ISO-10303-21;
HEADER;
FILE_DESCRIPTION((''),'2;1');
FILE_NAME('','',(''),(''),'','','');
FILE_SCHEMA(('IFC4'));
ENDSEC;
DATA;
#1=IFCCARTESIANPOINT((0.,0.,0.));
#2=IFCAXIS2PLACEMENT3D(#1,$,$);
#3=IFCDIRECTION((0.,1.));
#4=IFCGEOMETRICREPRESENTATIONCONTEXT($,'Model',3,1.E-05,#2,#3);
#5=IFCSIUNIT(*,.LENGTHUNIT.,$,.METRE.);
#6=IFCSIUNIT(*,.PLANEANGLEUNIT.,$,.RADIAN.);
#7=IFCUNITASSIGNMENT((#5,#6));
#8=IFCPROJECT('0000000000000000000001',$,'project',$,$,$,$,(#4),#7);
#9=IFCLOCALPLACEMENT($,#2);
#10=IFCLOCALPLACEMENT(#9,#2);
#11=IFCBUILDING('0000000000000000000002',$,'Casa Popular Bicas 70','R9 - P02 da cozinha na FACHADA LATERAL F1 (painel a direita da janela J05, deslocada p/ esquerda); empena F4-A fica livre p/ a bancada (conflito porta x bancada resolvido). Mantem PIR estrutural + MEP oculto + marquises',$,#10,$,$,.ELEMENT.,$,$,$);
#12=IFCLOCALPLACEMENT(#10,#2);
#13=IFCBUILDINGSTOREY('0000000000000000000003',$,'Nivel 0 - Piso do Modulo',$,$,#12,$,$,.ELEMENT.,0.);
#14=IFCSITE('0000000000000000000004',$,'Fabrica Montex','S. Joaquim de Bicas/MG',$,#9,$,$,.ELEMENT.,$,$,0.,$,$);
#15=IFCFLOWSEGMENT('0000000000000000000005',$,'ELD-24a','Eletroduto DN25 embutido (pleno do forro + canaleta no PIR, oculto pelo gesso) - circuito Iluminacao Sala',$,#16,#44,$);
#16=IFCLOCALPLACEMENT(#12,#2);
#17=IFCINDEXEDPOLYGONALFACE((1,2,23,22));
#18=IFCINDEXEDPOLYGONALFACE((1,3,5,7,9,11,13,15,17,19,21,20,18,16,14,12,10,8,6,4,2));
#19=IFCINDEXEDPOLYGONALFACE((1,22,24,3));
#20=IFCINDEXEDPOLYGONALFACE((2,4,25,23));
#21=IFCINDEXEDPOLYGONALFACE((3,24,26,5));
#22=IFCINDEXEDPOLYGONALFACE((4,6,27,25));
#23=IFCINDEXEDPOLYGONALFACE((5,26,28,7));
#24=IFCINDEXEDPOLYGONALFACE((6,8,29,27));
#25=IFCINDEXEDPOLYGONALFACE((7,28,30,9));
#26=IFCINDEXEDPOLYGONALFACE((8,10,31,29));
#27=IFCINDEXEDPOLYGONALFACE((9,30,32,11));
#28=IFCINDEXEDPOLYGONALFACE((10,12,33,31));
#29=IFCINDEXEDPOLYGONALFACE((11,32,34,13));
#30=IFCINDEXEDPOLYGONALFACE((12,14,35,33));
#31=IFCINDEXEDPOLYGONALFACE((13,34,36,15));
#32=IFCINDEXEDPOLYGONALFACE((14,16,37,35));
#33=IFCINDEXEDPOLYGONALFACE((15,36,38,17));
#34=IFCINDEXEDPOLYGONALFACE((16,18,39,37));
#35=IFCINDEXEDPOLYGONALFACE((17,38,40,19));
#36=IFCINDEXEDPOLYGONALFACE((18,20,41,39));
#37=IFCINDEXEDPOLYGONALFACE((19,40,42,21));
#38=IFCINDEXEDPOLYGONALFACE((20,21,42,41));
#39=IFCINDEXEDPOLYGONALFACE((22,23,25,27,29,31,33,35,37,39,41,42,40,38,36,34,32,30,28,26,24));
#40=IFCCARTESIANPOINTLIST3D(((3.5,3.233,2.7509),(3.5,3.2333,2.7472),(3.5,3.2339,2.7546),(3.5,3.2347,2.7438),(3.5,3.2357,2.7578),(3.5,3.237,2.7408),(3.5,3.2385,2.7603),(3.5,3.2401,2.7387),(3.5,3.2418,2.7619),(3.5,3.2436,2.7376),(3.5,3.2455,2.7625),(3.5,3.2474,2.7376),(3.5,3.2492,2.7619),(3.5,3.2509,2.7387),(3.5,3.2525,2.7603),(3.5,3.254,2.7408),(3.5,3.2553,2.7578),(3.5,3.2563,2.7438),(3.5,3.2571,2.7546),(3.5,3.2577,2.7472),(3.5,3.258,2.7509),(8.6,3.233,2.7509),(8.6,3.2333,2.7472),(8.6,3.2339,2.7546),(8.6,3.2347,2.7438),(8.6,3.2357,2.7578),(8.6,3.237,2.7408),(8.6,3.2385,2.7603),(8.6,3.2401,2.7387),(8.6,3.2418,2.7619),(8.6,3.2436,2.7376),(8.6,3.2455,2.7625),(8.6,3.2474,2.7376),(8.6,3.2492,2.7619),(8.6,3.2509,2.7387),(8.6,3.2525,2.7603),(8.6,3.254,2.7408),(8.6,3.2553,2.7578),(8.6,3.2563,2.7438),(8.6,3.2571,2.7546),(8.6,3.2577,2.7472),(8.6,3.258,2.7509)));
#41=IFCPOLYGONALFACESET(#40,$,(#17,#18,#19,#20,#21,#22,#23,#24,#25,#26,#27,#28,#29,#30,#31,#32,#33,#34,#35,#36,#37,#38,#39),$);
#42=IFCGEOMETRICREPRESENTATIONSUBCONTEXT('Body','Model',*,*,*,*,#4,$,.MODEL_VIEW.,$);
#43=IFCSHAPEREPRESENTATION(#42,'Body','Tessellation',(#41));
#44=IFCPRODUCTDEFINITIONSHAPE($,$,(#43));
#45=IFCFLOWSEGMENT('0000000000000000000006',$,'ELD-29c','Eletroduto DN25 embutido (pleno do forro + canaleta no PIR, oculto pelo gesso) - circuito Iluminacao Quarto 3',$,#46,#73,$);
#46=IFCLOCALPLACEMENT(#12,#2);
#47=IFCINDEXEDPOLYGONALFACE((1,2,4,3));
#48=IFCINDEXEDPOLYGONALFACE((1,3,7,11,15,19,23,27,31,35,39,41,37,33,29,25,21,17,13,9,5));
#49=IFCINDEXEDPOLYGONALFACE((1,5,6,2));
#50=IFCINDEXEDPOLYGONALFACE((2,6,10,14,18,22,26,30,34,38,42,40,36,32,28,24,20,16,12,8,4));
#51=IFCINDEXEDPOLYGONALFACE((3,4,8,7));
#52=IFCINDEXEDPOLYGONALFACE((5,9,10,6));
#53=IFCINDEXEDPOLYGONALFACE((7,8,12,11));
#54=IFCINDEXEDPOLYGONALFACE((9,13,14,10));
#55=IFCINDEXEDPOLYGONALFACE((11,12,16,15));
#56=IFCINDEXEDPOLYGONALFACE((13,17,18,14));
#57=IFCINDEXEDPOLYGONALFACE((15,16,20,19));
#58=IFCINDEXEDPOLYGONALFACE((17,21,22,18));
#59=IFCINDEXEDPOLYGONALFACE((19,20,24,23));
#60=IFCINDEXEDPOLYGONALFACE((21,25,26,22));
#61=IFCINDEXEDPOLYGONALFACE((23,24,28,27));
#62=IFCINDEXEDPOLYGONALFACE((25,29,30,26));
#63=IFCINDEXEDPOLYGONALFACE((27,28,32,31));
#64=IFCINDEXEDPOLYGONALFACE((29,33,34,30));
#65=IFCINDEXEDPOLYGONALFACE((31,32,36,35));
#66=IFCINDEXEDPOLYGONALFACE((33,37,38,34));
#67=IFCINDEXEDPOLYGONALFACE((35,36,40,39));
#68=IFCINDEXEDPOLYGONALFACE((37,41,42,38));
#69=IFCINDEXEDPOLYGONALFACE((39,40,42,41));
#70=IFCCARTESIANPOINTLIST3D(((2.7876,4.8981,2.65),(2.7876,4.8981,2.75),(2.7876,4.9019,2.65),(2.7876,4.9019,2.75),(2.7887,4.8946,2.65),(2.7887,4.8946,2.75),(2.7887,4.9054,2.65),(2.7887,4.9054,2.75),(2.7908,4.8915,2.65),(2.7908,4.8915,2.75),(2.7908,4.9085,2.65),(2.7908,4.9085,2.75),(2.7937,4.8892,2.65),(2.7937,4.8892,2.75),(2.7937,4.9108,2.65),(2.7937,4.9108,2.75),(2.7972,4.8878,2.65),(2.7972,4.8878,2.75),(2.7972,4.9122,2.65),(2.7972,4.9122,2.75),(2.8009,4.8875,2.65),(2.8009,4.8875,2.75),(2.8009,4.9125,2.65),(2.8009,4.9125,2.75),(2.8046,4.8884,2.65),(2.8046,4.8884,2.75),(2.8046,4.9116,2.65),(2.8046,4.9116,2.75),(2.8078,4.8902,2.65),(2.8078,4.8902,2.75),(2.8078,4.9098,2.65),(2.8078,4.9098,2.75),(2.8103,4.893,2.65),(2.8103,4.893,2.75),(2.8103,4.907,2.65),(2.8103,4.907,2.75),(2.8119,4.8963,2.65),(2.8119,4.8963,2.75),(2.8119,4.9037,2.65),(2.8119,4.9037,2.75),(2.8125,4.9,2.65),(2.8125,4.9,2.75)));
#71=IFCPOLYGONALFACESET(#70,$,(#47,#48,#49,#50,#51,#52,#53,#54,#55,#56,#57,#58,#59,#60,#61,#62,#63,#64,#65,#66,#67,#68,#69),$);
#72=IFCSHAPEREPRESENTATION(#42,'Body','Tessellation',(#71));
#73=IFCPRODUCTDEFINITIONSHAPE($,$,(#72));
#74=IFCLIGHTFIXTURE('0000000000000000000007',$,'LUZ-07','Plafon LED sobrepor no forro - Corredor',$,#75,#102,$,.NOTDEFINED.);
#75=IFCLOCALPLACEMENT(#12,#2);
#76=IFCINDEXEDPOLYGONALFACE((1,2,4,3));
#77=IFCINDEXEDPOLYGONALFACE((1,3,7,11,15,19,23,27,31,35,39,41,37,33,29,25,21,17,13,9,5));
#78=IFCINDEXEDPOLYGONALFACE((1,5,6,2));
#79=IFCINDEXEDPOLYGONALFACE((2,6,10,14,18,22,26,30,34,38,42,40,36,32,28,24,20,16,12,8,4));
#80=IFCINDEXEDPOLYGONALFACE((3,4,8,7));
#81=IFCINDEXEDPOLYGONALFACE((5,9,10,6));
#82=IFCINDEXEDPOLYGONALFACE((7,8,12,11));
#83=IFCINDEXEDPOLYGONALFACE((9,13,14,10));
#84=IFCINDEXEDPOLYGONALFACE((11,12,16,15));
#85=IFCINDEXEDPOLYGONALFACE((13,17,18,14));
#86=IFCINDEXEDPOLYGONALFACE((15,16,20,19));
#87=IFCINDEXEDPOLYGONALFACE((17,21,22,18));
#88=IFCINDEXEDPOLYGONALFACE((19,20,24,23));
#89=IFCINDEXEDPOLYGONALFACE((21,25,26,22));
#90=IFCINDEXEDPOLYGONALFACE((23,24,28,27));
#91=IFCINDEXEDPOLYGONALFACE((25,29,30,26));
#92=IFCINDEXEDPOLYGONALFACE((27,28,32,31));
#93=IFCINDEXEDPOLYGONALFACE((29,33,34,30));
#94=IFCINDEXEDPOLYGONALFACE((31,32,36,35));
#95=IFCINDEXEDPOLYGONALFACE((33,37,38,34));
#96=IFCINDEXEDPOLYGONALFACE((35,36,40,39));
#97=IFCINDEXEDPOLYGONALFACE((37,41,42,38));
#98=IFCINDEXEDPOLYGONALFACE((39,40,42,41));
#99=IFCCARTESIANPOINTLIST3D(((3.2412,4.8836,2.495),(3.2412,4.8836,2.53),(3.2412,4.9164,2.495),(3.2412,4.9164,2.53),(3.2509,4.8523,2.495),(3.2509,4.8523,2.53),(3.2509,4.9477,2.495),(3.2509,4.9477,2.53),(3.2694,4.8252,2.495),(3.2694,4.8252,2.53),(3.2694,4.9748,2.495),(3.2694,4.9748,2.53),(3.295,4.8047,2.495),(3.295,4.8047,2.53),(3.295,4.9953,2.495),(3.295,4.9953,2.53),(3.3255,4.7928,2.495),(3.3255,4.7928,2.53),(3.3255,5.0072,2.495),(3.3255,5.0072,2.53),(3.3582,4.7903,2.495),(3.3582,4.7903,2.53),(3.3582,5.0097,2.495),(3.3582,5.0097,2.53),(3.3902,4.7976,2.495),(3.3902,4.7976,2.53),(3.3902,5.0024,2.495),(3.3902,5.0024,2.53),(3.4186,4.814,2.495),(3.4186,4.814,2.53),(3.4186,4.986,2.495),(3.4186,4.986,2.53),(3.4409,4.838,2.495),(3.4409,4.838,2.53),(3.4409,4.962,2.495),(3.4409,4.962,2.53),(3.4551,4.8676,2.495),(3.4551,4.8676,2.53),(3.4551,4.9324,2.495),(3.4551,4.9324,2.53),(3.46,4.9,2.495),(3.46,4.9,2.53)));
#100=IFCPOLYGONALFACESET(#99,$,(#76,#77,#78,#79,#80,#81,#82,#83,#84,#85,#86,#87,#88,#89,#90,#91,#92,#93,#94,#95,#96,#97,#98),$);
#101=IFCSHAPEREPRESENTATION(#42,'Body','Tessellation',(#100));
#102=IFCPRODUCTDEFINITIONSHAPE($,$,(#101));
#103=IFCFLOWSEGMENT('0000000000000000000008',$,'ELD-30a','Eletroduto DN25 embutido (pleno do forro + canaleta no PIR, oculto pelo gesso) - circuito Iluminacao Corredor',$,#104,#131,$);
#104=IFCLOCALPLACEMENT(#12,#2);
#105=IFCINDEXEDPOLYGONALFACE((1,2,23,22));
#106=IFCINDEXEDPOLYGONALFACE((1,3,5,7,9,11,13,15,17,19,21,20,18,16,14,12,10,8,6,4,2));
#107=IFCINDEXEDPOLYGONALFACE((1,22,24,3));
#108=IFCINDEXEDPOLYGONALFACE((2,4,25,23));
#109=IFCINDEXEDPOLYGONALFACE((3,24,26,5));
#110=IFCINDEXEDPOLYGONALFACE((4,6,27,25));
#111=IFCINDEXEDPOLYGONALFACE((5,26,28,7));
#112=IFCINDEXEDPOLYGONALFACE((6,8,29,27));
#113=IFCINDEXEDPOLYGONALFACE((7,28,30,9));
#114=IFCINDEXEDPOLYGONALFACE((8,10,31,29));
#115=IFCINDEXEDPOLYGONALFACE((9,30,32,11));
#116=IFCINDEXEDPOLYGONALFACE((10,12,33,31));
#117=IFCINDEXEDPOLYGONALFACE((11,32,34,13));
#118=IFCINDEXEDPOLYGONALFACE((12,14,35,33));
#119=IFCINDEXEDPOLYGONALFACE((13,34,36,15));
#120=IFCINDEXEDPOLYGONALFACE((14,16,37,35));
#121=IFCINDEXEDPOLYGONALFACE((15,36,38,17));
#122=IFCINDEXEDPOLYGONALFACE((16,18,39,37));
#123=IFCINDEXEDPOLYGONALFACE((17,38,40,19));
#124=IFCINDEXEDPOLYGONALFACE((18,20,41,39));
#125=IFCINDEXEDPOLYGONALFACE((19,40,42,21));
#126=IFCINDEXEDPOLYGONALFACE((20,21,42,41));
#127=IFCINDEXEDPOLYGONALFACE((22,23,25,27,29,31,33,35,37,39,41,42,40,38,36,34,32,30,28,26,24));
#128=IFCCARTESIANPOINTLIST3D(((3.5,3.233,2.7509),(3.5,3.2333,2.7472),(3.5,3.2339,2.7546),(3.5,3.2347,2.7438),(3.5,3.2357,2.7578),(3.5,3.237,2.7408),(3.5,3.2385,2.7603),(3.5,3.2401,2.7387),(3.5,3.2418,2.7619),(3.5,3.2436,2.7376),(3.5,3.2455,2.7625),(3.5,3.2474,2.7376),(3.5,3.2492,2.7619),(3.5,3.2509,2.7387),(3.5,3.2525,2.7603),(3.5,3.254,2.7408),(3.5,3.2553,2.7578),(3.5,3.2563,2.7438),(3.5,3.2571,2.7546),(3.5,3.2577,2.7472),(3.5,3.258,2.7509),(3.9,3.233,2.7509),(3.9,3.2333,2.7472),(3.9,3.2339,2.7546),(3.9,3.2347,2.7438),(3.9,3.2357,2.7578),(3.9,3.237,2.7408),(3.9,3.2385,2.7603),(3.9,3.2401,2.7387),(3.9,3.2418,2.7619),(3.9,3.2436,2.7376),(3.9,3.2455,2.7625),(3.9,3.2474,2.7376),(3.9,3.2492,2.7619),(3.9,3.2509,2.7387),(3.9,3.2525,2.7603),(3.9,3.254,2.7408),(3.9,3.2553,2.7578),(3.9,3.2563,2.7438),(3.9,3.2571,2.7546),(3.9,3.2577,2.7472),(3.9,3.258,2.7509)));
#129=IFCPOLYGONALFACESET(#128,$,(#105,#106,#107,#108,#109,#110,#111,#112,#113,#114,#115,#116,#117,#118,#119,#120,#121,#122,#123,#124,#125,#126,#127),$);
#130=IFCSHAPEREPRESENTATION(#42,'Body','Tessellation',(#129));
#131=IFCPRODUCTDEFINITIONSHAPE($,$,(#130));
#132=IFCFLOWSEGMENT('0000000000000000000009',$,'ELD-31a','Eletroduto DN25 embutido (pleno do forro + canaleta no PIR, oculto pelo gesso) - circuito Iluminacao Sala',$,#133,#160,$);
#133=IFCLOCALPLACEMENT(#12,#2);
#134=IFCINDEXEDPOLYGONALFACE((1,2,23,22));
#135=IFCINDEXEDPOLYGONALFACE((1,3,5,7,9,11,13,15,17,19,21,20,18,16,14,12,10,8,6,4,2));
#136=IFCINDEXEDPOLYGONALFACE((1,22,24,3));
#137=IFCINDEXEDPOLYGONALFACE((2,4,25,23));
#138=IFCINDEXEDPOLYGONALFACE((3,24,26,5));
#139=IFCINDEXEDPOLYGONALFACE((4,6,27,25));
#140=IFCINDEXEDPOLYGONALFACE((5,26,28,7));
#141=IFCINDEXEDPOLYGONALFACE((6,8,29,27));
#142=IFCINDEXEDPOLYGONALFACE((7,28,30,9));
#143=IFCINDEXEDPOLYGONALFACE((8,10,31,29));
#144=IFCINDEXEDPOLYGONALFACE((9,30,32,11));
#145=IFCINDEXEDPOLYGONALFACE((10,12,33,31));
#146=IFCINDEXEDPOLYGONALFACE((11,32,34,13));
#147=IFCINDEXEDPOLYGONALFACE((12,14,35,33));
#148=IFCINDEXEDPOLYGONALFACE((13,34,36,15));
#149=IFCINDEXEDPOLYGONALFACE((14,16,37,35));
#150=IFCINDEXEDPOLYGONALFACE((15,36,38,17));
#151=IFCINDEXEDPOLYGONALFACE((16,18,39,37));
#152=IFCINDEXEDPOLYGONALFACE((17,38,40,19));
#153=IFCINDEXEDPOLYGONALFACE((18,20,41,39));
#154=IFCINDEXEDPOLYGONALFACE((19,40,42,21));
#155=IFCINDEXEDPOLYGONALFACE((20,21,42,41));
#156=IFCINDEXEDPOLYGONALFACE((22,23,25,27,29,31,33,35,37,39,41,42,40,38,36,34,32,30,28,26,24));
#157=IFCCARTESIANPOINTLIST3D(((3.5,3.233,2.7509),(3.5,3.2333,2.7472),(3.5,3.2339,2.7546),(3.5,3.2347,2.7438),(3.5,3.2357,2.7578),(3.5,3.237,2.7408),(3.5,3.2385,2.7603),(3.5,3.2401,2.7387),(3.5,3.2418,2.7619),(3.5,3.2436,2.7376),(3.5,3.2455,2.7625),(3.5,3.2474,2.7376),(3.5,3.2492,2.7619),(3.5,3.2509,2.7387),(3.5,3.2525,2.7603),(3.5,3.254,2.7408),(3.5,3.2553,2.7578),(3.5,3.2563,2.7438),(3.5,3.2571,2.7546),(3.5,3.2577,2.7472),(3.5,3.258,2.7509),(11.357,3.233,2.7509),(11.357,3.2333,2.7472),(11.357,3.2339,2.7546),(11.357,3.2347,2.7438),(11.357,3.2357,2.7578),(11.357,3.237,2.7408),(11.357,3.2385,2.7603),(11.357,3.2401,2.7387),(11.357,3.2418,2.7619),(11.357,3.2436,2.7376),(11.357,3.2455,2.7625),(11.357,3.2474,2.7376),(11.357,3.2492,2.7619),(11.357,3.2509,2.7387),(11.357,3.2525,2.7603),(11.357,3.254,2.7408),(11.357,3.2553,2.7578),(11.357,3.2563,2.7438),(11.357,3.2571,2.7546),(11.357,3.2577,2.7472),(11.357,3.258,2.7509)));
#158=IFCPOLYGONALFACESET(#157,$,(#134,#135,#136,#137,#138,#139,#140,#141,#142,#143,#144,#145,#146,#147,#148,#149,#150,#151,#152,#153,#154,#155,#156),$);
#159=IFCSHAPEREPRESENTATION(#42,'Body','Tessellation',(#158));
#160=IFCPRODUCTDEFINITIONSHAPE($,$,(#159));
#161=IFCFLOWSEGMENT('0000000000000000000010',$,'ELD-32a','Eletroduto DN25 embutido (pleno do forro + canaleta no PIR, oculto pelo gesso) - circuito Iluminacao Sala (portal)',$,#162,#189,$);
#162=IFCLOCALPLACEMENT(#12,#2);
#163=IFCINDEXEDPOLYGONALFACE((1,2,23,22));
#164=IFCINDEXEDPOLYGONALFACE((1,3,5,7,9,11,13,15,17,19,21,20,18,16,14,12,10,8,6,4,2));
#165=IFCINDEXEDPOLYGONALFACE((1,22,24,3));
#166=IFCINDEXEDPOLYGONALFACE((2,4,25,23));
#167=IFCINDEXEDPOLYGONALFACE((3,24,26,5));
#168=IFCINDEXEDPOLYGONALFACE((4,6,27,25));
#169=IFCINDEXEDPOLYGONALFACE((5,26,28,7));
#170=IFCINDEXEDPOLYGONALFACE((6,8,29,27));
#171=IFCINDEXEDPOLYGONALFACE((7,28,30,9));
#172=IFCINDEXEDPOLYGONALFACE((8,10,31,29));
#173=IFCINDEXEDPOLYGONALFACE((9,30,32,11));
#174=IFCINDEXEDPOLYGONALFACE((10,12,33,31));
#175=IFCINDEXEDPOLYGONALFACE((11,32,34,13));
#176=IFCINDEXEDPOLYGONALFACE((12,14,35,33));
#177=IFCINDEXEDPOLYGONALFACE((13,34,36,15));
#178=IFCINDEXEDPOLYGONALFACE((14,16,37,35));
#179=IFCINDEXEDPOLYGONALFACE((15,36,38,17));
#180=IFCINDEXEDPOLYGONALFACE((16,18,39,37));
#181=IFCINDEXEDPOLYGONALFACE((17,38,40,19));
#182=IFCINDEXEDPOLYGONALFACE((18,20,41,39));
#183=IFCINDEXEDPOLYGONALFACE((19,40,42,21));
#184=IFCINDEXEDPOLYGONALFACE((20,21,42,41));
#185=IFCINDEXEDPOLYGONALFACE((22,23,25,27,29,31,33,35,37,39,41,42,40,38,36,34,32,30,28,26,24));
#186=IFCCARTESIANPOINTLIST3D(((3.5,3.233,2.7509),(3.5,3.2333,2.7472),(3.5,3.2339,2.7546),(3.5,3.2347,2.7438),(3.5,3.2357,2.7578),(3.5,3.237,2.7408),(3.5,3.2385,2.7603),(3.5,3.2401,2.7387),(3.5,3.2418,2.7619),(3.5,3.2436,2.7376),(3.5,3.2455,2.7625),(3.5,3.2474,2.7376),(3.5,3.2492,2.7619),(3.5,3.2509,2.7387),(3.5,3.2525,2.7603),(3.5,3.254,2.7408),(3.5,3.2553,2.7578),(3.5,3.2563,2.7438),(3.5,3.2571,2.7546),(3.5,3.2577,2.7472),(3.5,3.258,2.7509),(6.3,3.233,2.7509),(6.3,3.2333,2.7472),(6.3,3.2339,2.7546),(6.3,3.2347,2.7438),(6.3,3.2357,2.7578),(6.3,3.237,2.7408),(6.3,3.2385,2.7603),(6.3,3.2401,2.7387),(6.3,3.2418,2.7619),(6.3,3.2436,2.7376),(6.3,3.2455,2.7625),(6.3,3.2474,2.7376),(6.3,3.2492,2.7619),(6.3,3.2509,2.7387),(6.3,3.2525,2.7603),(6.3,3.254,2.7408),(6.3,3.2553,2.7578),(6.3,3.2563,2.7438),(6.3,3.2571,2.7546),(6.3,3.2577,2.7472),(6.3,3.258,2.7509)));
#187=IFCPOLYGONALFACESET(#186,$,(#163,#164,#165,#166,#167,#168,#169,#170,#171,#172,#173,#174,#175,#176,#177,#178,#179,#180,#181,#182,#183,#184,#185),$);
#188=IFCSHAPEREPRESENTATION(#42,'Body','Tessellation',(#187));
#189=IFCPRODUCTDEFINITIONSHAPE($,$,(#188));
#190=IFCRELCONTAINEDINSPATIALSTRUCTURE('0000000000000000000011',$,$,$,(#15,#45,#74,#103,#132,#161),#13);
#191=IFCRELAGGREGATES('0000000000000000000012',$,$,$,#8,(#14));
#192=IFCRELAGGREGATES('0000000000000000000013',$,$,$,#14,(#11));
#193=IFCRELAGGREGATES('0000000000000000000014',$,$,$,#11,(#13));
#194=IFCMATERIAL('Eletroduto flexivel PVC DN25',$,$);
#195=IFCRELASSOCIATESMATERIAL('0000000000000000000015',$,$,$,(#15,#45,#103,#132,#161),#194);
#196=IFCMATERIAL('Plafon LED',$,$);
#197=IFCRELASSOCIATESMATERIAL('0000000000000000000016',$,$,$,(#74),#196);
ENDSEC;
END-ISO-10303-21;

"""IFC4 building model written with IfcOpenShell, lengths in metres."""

from ifc_helpers import new_model, si_unit, direction, frame, origin, origin_2d, place, context, subcontext, project, spatial, circle, extrude, material, element, save


model = new_model("IFC4")

# Units and contexts
model_context = context("Model", 3, precision=1e-05, world=origin(), true_north=direction((0.0, 1.0)))
body_context = subcontext(model_context, "Body", "Model", "MODEL_VIEW")
ifc_project = project(units=[si_unit("LENGTHUNIT", "METRE"), si_unit("PLANEANGLEUNIT", "RADIAN")], contexts=[model_context])

# Site, building, storey
site_placement = place(None, origin())
site = spatial("IfcSite", under=ifc_project, at=site_placement, Name="Fabrica Montex", Description="S. Joaquim de Bicas/MG", CompositionType="ELEMENT", RefElevation=0.0)
building_placement = place(site_placement, origin())
building = spatial("IfcBuilding", under=site, at=building_placement, Name="Casa Popular Bicas 70", Description="R9 - P02 da cozinha na FACHADA LATERAL F1 (painel a direita da janela J05, deslocada p/ esquerda); empena F4-A fica livre p/ a bancada (conflito porta x bancada resolvido). Mantem PIR estrutural + MEP oculto + marquises", CompositionType="ELEMENT")
storey_placement = place(building_placement, origin())
storey = spatial("IfcBuildingStorey", under=building, at=storey_placement, Name="Nivel 0 - Piso do Modulo", CompositionType="ELEMENT", Elevation=0.0)

# Flow segments
ifc_material_1 = material(Name="Eletroduto flexivel PVC DN25")
flow_segment_1_placement = place(storey_placement, frame((3.5, 3.2455, 2.75), z_axis=(1.0, 0.0, 0.0), x_axis=(0.0, 0.0, 1.0)))
element("IfcFlowSegment", 1, at=flow_segment_1_placement, inside=storey, material=ifc_material_1, Name="ELD-24a", Description="Eletroduto DN25 embutido (pleno do forro + canaleta no PIR, oculto pelo gesso) - circuito Iluminacao Sala", context=body_context, shape_type="SweptSolid", body=[
    extrude(circle(Radius=0.0125, at=origin_2d()), origin(), (0.0, 0.0, 1.0), 5.1),
])
flow_segment_2_placement = place(storey_placement, frame((2.8, 4.9, 2.75), z_axis=(0.0, 0.0, -1.0), x_axis=(1.0, 0.0, 0.0)))
element("IfcFlowSegment", 2, at=flow_segment_2_placement, inside=storey, material=ifc_material_1, Name="ELD-29c", Description="Eletroduto DN25 embutido (pleno do forro + canaleta no PIR, oculto pelo gesso) - circuito Iluminacao Quarto 3", context=body_context, shape_type="SweptSolid", body=[
    extrude(circle(Radius=0.0125, at=origin_2d()), origin(), (0.0, 0.0, 1.0), 0.1),
])

# Light fixture
ifc_material_2 = material(Name="Plafon LED")
light_fixture_placement = place(storey_placement, frame((3.35, 4.9, 2.495)))
element("IfcLightFixture", 3, at=light_fixture_placement, inside=storey, material=ifc_material_2, Name="LUZ-07", Description="Plafon LED sobrepor no forro - Corredor", PredefinedType="NOTDEFINED", context=body_context, shape_type="SweptSolid", body=[
    extrude(circle(Radius=0.11, at=origin_2d()), origin(), (0.0, 0.0, 1.0), 0.035),
])

# Flow segments
flow_segment_3_placement = place(storey_placement, frame((3.5, 3.2455, 2.75), z_axis=(1.0, 0.0, 0.0), x_axis=(0.0, 0.0, 1.0)))
element("IfcFlowSegment", 4, at=flow_segment_3_placement, inside=storey, material=ifc_material_1, Name="ELD-30a", Description="Eletroduto DN25 embutido (pleno do forro + canaleta no PIR, oculto pelo gesso) - circuito Iluminacao Corredor", context=body_context, shape_type="SweptSolid", body=[
    extrude(circle(Radius=0.0125, at=origin_2d()), origin(), (0.0, 0.0, 1.0), 0.4),
])
flow_segment_4_placement = place(storey_placement, frame((3.5, 3.2455, 2.75), z_axis=(1.0, 0.0, 0.0), x_axis=(0.0, 0.0, 1.0)))
element("IfcFlowSegment", 5, at=flow_segment_4_placement, inside=storey, material=ifc_material_1, Name="ELD-31a", Description="Eletroduto DN25 embutido (pleno do forro + canaleta no PIR, oculto pelo gesso) - circuito Iluminacao Sala", context=body_context, shape_type="SweptSolid", body=[
    extrude(circle(Radius=0.0125, at=origin_2d()), origin(), (0.0, 0.0, 1.0), 7.857),
])
flow_segment_5_placement = place(storey_placement, frame((3.5, 3.2455, 2.75), z_axis=(1.0, 0.0, 0.0), x_axis=(0.0, 0.0, 1.0)))
element("IfcFlowSegment", 6, at=flow_segment_5_placement, inside=storey, material=ifc_material_1, Name="ELD-32a", Description="Eletroduto DN25 embutido (pleno do forro + canaleta no PIR, oculto pelo gesso) - circuito Iluminacao Sala (portal)", context=body_context, shape_type="SweptSolid", body=[
    extrude(circle(Radius=0.0125, at=origin_2d()), origin(), (0.0, 0.0, 1.0), 2.8),
])

save(model, "model.ifc")
